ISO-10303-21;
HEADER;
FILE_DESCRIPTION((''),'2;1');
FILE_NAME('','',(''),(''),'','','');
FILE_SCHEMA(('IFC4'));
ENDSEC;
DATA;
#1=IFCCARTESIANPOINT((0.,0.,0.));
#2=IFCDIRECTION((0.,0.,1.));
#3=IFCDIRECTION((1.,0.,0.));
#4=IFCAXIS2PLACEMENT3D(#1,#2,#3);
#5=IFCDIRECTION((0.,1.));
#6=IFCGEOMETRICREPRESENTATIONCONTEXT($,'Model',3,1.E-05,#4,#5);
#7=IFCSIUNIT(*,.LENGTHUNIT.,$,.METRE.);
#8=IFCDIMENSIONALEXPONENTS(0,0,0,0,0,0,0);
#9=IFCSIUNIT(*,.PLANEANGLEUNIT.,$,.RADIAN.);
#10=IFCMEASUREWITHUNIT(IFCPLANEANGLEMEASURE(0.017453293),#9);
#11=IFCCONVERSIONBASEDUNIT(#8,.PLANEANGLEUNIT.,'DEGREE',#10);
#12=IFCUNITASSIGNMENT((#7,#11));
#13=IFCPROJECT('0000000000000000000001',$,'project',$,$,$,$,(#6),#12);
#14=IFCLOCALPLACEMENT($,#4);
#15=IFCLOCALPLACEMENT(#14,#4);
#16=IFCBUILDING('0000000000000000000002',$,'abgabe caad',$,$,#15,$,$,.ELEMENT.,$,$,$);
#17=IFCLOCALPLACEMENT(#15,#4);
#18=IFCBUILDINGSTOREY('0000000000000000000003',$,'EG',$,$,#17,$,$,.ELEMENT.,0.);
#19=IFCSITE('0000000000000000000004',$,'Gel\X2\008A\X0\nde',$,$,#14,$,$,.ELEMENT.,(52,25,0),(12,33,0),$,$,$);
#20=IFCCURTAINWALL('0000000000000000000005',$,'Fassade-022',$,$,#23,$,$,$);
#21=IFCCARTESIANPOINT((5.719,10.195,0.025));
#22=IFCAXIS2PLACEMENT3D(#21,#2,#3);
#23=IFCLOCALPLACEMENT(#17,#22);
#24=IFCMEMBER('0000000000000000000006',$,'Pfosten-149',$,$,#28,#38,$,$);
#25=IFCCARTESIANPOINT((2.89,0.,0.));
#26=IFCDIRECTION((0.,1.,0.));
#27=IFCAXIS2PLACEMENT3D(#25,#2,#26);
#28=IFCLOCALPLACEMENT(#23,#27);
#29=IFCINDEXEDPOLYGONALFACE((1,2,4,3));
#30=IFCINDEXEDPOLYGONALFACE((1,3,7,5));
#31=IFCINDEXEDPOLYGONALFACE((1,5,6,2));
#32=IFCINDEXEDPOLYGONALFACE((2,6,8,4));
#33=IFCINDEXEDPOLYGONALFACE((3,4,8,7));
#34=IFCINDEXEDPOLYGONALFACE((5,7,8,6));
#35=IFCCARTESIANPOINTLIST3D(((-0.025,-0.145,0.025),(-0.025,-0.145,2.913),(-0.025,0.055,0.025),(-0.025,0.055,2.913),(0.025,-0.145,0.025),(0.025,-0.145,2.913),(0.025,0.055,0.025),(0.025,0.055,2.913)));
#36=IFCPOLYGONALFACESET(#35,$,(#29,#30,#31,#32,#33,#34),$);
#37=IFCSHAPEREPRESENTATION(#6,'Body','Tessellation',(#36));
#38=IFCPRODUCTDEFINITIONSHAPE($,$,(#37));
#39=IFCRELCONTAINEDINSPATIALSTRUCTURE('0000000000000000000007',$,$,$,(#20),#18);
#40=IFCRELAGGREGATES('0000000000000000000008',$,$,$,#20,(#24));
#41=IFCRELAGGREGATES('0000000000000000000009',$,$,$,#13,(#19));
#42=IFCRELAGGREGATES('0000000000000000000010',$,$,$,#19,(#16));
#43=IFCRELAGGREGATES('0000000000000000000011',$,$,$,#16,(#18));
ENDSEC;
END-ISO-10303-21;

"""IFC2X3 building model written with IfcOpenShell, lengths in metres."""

from ifc_helpers import new_model, entity, si_unit, converted_unit, direction, frame, origin_with_axes, place, context, project, spatial, polyline, outline, extrude, element, aggregate, save


model = new_model("IFC2X3")

# Units and contexts
model_context = context("Model", 3, precision=1e-05, world=origin_with_axes(), true_north=direction((0.0, 1.0)))
ifc_project = project(units=[si_unit("LENGTHUNIT", "METRE"), converted_unit("PLANEANGLEUNIT", "DEGREE", entity("IfcPlaneAngleMeasure", 0.017453293), si_unit("PLANEANGLEUNIT", "RADIAN"), dimensions=[0, 0, 0, 0, 0, 0, 0])], contexts=[model_context])

# Site, building, storey
site_placement = place(None, origin_with_axes())
site = spatial("IfcSite", under=ifc_project, at=site_placement, Name="Gel\u008ande", CompositionType="ELEMENT", RefLatitude=(52, 25, 0), RefLongitude=(12, 33, 0))
building_placement = place(site_placement, origin_with_axes())
building = spatial("IfcBuilding", under=site, at=building_placement, Name="abgabe caad", CompositionType="ELEMENT")
storey_placement = place(building_placement, origin_with_axes())
storey = spatial("IfcBuildingStorey", under=building, at=storey_placement, Name="EG", CompositionType="ELEMENT", Elevation=0.0)

# Curtain wall, member
curtain_wall_placement = place(storey_placement, frame((5.719, 10.195, 0.025), z_axis=(0.0, 0.0, 1.0), x_axis=(1.0, 0.0, 0.0)))
curtain_wall = element("IfcCurtainWall", 1, at=curtain_wall_placement, inside=storey, Name="Fassade-022")
member_1_placement = place(curtain_wall_placement, frame((2.89, 0.0, 0.0), z_axis=(0.0, 0.0, 1.0), x_axis=(0.0, 1.0, 0.0)))
member_1 = element("IfcMember", 2, at=member_1_placement, Name="Pfosten-149", context=model_context, shape_type="SweptSolid", body=[
    extrude(outline(polyline([(0.145, 0.025), (-0.055, 0.025), (-0.055, -0.025), (0.145, -0.025), (0.145, 0.025)])), frame((0.0, 0.0, 0.025), z_axis=(0.0, 0.0, 1.0), x_axis=(0.0, -1.0, 0.0)), (0.0, 0.0, 1.0), 2.888),
])
aggregate(curtain_wall, [member_1])

save(model, "model.ifc")
